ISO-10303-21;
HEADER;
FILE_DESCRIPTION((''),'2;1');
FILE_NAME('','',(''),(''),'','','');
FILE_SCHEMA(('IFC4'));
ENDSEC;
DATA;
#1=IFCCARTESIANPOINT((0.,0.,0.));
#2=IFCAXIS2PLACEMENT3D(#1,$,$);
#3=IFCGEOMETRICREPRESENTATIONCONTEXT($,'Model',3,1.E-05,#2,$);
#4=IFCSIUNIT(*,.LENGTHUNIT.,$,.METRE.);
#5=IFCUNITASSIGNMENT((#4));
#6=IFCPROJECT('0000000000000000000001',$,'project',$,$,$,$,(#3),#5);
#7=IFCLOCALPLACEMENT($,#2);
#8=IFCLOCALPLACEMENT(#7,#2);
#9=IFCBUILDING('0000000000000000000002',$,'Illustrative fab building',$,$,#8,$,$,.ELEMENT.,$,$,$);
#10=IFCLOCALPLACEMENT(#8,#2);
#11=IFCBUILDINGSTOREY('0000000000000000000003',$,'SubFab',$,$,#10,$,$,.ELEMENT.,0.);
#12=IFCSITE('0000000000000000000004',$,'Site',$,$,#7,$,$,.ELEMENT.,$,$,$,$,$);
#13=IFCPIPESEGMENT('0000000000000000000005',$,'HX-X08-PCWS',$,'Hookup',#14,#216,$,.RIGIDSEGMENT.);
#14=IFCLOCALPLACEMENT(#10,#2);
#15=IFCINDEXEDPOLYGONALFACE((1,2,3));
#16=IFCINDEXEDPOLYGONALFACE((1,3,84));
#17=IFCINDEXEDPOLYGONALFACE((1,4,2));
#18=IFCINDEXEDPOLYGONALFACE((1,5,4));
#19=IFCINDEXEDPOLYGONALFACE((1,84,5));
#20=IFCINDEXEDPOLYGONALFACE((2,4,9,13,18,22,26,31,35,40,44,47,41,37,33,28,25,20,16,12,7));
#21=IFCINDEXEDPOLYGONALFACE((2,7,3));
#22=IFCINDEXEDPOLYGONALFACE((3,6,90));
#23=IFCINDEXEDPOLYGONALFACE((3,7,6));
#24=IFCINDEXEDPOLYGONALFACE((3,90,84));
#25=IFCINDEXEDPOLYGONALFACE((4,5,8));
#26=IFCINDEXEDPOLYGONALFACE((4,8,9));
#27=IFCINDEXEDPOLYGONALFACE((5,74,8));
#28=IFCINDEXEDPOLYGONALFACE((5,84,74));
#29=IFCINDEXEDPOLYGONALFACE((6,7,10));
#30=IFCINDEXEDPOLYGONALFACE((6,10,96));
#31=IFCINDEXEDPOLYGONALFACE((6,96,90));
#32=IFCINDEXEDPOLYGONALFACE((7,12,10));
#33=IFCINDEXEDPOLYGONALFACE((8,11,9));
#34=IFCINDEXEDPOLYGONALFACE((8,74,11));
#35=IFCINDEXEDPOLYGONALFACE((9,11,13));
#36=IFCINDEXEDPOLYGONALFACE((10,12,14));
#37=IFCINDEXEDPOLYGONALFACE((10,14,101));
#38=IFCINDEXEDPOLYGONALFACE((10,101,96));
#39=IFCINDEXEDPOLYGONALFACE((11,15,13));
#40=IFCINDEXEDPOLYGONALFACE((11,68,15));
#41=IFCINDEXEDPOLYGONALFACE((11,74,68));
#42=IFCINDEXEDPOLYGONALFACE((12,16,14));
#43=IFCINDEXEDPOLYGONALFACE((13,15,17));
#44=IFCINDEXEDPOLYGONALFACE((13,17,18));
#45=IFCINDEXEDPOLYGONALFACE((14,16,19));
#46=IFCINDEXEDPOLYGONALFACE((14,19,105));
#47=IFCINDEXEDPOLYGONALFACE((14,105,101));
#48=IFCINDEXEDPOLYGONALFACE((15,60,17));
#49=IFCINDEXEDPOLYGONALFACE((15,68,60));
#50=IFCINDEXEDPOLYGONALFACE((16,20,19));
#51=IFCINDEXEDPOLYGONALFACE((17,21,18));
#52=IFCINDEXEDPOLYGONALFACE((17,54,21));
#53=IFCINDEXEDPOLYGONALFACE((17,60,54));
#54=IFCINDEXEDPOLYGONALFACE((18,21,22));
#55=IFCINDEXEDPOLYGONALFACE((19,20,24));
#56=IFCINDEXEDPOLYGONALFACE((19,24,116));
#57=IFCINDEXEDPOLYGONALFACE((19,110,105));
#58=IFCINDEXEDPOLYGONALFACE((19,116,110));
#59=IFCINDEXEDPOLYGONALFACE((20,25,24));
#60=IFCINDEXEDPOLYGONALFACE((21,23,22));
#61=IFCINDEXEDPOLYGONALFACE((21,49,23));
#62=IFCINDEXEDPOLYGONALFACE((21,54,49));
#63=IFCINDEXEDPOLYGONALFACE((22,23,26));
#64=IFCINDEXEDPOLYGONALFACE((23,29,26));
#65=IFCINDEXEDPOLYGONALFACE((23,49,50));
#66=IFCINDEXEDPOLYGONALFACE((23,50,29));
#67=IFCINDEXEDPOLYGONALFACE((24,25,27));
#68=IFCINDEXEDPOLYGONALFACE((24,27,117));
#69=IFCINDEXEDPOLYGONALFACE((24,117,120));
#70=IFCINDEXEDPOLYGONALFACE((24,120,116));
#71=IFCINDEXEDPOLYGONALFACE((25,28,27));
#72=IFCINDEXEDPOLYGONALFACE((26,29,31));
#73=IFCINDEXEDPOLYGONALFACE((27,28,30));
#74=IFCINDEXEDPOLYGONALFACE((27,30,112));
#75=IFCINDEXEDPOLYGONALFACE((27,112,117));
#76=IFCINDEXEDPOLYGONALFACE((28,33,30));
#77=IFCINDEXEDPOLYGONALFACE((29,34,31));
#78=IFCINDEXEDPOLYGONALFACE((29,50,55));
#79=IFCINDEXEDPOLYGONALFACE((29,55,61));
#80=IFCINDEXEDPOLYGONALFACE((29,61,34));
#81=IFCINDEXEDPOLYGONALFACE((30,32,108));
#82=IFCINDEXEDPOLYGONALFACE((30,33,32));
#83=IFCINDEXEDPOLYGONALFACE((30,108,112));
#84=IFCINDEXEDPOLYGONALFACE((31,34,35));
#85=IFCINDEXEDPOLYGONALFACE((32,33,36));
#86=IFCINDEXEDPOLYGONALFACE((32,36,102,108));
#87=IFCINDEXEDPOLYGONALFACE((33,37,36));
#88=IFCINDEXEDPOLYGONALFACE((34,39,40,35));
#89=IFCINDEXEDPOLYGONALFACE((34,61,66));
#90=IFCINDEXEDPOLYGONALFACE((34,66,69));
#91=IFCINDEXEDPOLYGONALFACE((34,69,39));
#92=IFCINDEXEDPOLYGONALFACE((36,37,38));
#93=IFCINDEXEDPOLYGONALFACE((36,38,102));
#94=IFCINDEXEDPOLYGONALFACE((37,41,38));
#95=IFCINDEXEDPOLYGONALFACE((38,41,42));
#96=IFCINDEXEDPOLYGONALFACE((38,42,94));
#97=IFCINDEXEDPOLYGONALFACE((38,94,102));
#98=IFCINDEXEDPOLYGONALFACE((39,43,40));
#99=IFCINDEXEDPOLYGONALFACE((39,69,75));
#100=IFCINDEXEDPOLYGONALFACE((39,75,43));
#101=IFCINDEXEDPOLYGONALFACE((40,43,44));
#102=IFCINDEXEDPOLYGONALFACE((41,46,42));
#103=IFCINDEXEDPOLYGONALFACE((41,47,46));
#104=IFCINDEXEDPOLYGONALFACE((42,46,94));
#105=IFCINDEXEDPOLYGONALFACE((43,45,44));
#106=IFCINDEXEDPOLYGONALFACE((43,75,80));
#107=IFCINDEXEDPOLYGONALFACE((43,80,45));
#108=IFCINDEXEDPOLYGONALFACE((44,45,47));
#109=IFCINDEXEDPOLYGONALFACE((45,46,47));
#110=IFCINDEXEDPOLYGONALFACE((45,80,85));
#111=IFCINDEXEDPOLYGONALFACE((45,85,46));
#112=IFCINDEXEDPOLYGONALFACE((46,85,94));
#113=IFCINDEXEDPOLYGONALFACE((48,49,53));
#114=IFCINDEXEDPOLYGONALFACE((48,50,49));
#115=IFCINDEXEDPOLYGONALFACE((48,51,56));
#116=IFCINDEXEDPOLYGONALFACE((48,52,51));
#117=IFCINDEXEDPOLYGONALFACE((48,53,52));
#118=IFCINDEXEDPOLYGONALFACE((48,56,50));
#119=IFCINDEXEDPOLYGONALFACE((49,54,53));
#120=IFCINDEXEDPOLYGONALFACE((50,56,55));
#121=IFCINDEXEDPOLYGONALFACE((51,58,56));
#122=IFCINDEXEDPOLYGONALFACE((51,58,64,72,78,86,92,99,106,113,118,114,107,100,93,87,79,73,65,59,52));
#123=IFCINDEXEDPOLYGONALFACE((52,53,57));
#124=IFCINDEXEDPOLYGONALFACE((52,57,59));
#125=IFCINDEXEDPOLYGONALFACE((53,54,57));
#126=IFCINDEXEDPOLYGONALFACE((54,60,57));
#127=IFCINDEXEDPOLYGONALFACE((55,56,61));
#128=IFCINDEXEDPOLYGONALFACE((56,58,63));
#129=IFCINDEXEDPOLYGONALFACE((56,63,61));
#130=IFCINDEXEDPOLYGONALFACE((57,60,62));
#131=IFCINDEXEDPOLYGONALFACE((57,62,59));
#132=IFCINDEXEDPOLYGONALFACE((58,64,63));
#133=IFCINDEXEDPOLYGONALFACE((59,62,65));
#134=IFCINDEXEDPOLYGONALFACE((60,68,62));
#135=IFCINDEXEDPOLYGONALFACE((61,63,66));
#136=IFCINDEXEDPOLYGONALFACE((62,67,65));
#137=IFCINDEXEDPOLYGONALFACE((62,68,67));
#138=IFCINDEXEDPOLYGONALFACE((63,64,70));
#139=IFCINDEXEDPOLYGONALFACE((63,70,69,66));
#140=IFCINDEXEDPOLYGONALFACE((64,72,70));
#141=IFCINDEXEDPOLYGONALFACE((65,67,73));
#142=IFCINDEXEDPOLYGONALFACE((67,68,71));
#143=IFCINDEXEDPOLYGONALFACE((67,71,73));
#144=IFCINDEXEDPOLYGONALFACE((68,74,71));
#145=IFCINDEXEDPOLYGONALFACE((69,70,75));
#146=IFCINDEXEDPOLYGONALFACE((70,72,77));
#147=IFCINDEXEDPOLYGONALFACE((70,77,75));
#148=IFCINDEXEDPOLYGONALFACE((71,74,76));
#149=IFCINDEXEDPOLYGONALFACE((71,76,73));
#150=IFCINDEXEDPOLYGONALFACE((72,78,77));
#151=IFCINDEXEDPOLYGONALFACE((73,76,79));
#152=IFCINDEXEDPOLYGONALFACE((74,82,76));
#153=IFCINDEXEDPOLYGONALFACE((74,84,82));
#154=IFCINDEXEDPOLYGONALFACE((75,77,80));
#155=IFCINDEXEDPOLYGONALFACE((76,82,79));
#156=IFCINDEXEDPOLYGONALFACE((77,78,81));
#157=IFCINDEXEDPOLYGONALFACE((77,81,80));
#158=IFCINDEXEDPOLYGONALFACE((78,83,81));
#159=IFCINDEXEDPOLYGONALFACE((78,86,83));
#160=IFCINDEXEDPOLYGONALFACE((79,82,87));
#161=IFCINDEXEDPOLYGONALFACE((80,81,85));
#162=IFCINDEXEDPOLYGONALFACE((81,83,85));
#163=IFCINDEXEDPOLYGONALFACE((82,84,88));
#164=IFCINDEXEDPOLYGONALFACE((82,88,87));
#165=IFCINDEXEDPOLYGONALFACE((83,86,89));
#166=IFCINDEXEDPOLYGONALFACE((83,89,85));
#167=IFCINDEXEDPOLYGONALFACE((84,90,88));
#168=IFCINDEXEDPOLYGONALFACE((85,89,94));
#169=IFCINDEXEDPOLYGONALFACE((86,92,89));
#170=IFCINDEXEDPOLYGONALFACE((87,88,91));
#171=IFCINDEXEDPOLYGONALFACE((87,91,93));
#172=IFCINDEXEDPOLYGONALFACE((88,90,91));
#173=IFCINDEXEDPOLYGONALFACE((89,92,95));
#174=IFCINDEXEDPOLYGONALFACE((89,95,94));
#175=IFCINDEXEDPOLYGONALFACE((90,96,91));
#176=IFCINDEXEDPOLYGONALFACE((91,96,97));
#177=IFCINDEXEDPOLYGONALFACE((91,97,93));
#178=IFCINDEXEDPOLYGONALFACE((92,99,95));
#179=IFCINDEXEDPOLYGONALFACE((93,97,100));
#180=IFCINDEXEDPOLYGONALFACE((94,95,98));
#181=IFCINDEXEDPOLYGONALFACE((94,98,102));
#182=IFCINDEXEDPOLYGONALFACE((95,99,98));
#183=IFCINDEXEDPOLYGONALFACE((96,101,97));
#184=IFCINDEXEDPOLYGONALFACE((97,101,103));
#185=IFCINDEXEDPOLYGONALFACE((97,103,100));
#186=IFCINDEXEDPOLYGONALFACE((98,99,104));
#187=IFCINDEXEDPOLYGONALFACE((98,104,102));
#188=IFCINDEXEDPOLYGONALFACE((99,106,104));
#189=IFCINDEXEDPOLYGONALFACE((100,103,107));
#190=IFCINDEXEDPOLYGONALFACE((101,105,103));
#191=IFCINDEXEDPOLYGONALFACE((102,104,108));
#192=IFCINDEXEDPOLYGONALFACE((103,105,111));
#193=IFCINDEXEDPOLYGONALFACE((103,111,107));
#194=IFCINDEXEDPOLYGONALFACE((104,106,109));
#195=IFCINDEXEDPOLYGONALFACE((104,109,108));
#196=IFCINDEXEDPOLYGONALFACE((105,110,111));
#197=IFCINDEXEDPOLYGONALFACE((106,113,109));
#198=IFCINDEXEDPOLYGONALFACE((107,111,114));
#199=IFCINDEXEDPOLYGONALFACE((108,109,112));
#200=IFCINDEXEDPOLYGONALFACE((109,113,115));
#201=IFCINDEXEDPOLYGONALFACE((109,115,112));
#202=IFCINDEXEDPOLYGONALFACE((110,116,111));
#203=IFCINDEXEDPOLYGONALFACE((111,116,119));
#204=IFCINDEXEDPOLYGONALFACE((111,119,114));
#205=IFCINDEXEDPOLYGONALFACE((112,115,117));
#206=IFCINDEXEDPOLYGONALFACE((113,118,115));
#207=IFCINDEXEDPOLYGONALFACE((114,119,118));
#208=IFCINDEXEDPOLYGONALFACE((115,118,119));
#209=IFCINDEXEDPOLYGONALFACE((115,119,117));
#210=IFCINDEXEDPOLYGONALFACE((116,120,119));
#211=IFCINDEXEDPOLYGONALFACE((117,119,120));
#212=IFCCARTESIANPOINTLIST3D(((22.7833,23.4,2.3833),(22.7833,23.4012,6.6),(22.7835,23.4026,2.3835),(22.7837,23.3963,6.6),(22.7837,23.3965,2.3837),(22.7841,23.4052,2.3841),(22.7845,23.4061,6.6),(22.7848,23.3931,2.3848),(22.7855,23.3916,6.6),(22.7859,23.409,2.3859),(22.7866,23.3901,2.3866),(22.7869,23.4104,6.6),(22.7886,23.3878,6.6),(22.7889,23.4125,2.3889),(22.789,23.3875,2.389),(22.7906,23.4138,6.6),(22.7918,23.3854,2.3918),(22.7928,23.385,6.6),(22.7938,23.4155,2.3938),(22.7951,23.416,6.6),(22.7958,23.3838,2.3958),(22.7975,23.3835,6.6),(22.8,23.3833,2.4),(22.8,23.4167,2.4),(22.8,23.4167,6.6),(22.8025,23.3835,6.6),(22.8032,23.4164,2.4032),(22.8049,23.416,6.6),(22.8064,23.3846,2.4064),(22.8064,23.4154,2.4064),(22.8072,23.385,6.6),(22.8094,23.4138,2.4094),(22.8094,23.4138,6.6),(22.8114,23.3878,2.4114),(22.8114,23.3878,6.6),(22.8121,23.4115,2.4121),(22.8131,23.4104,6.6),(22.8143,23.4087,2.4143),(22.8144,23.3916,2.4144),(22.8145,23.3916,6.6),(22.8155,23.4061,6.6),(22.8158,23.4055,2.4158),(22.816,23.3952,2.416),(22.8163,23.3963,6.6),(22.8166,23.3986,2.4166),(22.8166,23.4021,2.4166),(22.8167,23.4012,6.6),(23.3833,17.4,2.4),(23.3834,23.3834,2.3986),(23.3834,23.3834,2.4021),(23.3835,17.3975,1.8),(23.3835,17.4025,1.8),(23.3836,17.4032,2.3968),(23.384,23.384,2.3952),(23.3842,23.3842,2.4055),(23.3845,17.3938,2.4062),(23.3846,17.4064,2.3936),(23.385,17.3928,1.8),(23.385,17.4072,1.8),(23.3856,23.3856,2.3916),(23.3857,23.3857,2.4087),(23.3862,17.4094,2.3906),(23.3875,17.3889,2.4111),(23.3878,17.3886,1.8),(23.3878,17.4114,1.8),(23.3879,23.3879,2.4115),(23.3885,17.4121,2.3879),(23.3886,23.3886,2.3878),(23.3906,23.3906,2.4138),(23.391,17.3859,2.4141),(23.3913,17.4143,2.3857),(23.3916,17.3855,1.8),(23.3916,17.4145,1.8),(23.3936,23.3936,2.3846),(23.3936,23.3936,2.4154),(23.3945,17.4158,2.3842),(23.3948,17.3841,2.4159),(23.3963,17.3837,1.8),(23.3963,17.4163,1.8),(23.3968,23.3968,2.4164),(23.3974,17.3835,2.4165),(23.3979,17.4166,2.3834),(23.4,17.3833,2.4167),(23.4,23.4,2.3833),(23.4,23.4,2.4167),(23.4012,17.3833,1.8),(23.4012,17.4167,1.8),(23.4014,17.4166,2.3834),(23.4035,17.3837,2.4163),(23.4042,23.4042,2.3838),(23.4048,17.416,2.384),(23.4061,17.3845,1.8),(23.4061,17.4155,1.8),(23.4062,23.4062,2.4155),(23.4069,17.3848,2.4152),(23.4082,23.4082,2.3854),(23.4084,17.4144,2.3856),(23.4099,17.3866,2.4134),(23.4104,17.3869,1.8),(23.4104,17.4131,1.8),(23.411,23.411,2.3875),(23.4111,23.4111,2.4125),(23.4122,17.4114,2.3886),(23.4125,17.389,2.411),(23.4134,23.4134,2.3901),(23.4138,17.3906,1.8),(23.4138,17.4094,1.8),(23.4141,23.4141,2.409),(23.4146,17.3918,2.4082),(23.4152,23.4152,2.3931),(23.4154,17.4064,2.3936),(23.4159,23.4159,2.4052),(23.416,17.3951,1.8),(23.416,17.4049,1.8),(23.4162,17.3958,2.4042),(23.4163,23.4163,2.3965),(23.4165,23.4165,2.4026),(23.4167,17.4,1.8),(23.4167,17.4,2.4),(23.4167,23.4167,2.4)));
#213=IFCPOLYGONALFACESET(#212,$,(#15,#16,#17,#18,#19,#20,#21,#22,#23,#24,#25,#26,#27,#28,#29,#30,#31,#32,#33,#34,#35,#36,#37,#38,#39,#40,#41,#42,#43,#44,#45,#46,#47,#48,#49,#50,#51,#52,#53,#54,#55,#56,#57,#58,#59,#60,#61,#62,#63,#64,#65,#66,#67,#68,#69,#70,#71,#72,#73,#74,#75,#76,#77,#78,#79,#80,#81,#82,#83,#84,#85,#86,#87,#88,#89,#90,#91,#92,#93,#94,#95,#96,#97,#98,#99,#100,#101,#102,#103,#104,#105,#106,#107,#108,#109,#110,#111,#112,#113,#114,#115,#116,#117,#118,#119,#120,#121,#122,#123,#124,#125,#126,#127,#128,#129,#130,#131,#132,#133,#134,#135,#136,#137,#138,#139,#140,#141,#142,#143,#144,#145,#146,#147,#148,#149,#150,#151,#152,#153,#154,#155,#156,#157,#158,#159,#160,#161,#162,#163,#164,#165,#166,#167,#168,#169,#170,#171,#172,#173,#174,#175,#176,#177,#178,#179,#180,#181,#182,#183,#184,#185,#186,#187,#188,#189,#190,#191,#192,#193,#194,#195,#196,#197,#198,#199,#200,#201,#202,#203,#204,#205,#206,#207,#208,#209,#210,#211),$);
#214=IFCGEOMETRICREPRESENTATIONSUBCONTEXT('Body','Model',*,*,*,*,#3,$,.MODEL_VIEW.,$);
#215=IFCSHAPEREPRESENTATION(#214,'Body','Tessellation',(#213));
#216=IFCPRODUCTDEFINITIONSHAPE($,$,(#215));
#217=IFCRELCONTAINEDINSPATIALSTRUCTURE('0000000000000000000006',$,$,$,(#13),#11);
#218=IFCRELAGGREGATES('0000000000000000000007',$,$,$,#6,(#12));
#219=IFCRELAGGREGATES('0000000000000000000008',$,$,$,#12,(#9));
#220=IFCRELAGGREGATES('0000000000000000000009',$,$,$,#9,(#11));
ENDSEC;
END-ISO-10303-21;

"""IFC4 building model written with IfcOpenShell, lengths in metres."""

from ifc_helpers import new_model, entity, si_unit, origin, place, context, subcontext, project, spatial, element, save


model = new_model("IFC4")

# Units and contexts
model_context = context("Model", 3, precision=1e-05, world=origin())
body_context = subcontext(model_context, "Body", "Model", "MODEL_VIEW")
ifc_project = project(units=[si_unit("LENGTHUNIT", "METRE")], contexts=[model_context])

# Site, building, storey
site_placement = place(None, origin())
site = spatial("IfcSite", under=ifc_project, at=site_placement, Name="Site", CompositionType="ELEMENT")
building_placement = place(site_placement, origin())
building = spatial("IfcBuilding", under=site, at=building_placement, Name="Illustrative fab building", CompositionType="ELEMENT")
storey_placement = place(building_placement, origin())
storey = spatial("IfcBuildingStorey", under=building, at=storey_placement, Name="SubFab", CompositionType="ELEMENT", Elevation=0.0)

# Pipe segment
pipe_segment_1_placement = place(storey_placement, origin())
element("IfcPipeSegment", 1, at=pipe_segment_1_placement, inside=storey, Name="HX-X08-PCWS", ObjectType="Hookup", PredefinedType="RIGIDSEGMENT", context=body_context, shape_type="AdvancedSweptSolid", body=[
    entity("IfcSweptDiskSolid", entity("IfcPolyline", [entity("IfcCartesianPoint", [23.4, 17.4, 1.8]), entity("IfcCartesianPoint", [23.4, 17.4, 2.4]), entity("IfcCartesianPoint", [23.4, 23.4, 2.4]), entity("IfcCartesianPoint", [22.8, 23.4, 2.4]), entity("IfcCartesianPoint", [22.8, 23.4, 6.6])]), 0.0167),
])

save(model, "model.ifc")
